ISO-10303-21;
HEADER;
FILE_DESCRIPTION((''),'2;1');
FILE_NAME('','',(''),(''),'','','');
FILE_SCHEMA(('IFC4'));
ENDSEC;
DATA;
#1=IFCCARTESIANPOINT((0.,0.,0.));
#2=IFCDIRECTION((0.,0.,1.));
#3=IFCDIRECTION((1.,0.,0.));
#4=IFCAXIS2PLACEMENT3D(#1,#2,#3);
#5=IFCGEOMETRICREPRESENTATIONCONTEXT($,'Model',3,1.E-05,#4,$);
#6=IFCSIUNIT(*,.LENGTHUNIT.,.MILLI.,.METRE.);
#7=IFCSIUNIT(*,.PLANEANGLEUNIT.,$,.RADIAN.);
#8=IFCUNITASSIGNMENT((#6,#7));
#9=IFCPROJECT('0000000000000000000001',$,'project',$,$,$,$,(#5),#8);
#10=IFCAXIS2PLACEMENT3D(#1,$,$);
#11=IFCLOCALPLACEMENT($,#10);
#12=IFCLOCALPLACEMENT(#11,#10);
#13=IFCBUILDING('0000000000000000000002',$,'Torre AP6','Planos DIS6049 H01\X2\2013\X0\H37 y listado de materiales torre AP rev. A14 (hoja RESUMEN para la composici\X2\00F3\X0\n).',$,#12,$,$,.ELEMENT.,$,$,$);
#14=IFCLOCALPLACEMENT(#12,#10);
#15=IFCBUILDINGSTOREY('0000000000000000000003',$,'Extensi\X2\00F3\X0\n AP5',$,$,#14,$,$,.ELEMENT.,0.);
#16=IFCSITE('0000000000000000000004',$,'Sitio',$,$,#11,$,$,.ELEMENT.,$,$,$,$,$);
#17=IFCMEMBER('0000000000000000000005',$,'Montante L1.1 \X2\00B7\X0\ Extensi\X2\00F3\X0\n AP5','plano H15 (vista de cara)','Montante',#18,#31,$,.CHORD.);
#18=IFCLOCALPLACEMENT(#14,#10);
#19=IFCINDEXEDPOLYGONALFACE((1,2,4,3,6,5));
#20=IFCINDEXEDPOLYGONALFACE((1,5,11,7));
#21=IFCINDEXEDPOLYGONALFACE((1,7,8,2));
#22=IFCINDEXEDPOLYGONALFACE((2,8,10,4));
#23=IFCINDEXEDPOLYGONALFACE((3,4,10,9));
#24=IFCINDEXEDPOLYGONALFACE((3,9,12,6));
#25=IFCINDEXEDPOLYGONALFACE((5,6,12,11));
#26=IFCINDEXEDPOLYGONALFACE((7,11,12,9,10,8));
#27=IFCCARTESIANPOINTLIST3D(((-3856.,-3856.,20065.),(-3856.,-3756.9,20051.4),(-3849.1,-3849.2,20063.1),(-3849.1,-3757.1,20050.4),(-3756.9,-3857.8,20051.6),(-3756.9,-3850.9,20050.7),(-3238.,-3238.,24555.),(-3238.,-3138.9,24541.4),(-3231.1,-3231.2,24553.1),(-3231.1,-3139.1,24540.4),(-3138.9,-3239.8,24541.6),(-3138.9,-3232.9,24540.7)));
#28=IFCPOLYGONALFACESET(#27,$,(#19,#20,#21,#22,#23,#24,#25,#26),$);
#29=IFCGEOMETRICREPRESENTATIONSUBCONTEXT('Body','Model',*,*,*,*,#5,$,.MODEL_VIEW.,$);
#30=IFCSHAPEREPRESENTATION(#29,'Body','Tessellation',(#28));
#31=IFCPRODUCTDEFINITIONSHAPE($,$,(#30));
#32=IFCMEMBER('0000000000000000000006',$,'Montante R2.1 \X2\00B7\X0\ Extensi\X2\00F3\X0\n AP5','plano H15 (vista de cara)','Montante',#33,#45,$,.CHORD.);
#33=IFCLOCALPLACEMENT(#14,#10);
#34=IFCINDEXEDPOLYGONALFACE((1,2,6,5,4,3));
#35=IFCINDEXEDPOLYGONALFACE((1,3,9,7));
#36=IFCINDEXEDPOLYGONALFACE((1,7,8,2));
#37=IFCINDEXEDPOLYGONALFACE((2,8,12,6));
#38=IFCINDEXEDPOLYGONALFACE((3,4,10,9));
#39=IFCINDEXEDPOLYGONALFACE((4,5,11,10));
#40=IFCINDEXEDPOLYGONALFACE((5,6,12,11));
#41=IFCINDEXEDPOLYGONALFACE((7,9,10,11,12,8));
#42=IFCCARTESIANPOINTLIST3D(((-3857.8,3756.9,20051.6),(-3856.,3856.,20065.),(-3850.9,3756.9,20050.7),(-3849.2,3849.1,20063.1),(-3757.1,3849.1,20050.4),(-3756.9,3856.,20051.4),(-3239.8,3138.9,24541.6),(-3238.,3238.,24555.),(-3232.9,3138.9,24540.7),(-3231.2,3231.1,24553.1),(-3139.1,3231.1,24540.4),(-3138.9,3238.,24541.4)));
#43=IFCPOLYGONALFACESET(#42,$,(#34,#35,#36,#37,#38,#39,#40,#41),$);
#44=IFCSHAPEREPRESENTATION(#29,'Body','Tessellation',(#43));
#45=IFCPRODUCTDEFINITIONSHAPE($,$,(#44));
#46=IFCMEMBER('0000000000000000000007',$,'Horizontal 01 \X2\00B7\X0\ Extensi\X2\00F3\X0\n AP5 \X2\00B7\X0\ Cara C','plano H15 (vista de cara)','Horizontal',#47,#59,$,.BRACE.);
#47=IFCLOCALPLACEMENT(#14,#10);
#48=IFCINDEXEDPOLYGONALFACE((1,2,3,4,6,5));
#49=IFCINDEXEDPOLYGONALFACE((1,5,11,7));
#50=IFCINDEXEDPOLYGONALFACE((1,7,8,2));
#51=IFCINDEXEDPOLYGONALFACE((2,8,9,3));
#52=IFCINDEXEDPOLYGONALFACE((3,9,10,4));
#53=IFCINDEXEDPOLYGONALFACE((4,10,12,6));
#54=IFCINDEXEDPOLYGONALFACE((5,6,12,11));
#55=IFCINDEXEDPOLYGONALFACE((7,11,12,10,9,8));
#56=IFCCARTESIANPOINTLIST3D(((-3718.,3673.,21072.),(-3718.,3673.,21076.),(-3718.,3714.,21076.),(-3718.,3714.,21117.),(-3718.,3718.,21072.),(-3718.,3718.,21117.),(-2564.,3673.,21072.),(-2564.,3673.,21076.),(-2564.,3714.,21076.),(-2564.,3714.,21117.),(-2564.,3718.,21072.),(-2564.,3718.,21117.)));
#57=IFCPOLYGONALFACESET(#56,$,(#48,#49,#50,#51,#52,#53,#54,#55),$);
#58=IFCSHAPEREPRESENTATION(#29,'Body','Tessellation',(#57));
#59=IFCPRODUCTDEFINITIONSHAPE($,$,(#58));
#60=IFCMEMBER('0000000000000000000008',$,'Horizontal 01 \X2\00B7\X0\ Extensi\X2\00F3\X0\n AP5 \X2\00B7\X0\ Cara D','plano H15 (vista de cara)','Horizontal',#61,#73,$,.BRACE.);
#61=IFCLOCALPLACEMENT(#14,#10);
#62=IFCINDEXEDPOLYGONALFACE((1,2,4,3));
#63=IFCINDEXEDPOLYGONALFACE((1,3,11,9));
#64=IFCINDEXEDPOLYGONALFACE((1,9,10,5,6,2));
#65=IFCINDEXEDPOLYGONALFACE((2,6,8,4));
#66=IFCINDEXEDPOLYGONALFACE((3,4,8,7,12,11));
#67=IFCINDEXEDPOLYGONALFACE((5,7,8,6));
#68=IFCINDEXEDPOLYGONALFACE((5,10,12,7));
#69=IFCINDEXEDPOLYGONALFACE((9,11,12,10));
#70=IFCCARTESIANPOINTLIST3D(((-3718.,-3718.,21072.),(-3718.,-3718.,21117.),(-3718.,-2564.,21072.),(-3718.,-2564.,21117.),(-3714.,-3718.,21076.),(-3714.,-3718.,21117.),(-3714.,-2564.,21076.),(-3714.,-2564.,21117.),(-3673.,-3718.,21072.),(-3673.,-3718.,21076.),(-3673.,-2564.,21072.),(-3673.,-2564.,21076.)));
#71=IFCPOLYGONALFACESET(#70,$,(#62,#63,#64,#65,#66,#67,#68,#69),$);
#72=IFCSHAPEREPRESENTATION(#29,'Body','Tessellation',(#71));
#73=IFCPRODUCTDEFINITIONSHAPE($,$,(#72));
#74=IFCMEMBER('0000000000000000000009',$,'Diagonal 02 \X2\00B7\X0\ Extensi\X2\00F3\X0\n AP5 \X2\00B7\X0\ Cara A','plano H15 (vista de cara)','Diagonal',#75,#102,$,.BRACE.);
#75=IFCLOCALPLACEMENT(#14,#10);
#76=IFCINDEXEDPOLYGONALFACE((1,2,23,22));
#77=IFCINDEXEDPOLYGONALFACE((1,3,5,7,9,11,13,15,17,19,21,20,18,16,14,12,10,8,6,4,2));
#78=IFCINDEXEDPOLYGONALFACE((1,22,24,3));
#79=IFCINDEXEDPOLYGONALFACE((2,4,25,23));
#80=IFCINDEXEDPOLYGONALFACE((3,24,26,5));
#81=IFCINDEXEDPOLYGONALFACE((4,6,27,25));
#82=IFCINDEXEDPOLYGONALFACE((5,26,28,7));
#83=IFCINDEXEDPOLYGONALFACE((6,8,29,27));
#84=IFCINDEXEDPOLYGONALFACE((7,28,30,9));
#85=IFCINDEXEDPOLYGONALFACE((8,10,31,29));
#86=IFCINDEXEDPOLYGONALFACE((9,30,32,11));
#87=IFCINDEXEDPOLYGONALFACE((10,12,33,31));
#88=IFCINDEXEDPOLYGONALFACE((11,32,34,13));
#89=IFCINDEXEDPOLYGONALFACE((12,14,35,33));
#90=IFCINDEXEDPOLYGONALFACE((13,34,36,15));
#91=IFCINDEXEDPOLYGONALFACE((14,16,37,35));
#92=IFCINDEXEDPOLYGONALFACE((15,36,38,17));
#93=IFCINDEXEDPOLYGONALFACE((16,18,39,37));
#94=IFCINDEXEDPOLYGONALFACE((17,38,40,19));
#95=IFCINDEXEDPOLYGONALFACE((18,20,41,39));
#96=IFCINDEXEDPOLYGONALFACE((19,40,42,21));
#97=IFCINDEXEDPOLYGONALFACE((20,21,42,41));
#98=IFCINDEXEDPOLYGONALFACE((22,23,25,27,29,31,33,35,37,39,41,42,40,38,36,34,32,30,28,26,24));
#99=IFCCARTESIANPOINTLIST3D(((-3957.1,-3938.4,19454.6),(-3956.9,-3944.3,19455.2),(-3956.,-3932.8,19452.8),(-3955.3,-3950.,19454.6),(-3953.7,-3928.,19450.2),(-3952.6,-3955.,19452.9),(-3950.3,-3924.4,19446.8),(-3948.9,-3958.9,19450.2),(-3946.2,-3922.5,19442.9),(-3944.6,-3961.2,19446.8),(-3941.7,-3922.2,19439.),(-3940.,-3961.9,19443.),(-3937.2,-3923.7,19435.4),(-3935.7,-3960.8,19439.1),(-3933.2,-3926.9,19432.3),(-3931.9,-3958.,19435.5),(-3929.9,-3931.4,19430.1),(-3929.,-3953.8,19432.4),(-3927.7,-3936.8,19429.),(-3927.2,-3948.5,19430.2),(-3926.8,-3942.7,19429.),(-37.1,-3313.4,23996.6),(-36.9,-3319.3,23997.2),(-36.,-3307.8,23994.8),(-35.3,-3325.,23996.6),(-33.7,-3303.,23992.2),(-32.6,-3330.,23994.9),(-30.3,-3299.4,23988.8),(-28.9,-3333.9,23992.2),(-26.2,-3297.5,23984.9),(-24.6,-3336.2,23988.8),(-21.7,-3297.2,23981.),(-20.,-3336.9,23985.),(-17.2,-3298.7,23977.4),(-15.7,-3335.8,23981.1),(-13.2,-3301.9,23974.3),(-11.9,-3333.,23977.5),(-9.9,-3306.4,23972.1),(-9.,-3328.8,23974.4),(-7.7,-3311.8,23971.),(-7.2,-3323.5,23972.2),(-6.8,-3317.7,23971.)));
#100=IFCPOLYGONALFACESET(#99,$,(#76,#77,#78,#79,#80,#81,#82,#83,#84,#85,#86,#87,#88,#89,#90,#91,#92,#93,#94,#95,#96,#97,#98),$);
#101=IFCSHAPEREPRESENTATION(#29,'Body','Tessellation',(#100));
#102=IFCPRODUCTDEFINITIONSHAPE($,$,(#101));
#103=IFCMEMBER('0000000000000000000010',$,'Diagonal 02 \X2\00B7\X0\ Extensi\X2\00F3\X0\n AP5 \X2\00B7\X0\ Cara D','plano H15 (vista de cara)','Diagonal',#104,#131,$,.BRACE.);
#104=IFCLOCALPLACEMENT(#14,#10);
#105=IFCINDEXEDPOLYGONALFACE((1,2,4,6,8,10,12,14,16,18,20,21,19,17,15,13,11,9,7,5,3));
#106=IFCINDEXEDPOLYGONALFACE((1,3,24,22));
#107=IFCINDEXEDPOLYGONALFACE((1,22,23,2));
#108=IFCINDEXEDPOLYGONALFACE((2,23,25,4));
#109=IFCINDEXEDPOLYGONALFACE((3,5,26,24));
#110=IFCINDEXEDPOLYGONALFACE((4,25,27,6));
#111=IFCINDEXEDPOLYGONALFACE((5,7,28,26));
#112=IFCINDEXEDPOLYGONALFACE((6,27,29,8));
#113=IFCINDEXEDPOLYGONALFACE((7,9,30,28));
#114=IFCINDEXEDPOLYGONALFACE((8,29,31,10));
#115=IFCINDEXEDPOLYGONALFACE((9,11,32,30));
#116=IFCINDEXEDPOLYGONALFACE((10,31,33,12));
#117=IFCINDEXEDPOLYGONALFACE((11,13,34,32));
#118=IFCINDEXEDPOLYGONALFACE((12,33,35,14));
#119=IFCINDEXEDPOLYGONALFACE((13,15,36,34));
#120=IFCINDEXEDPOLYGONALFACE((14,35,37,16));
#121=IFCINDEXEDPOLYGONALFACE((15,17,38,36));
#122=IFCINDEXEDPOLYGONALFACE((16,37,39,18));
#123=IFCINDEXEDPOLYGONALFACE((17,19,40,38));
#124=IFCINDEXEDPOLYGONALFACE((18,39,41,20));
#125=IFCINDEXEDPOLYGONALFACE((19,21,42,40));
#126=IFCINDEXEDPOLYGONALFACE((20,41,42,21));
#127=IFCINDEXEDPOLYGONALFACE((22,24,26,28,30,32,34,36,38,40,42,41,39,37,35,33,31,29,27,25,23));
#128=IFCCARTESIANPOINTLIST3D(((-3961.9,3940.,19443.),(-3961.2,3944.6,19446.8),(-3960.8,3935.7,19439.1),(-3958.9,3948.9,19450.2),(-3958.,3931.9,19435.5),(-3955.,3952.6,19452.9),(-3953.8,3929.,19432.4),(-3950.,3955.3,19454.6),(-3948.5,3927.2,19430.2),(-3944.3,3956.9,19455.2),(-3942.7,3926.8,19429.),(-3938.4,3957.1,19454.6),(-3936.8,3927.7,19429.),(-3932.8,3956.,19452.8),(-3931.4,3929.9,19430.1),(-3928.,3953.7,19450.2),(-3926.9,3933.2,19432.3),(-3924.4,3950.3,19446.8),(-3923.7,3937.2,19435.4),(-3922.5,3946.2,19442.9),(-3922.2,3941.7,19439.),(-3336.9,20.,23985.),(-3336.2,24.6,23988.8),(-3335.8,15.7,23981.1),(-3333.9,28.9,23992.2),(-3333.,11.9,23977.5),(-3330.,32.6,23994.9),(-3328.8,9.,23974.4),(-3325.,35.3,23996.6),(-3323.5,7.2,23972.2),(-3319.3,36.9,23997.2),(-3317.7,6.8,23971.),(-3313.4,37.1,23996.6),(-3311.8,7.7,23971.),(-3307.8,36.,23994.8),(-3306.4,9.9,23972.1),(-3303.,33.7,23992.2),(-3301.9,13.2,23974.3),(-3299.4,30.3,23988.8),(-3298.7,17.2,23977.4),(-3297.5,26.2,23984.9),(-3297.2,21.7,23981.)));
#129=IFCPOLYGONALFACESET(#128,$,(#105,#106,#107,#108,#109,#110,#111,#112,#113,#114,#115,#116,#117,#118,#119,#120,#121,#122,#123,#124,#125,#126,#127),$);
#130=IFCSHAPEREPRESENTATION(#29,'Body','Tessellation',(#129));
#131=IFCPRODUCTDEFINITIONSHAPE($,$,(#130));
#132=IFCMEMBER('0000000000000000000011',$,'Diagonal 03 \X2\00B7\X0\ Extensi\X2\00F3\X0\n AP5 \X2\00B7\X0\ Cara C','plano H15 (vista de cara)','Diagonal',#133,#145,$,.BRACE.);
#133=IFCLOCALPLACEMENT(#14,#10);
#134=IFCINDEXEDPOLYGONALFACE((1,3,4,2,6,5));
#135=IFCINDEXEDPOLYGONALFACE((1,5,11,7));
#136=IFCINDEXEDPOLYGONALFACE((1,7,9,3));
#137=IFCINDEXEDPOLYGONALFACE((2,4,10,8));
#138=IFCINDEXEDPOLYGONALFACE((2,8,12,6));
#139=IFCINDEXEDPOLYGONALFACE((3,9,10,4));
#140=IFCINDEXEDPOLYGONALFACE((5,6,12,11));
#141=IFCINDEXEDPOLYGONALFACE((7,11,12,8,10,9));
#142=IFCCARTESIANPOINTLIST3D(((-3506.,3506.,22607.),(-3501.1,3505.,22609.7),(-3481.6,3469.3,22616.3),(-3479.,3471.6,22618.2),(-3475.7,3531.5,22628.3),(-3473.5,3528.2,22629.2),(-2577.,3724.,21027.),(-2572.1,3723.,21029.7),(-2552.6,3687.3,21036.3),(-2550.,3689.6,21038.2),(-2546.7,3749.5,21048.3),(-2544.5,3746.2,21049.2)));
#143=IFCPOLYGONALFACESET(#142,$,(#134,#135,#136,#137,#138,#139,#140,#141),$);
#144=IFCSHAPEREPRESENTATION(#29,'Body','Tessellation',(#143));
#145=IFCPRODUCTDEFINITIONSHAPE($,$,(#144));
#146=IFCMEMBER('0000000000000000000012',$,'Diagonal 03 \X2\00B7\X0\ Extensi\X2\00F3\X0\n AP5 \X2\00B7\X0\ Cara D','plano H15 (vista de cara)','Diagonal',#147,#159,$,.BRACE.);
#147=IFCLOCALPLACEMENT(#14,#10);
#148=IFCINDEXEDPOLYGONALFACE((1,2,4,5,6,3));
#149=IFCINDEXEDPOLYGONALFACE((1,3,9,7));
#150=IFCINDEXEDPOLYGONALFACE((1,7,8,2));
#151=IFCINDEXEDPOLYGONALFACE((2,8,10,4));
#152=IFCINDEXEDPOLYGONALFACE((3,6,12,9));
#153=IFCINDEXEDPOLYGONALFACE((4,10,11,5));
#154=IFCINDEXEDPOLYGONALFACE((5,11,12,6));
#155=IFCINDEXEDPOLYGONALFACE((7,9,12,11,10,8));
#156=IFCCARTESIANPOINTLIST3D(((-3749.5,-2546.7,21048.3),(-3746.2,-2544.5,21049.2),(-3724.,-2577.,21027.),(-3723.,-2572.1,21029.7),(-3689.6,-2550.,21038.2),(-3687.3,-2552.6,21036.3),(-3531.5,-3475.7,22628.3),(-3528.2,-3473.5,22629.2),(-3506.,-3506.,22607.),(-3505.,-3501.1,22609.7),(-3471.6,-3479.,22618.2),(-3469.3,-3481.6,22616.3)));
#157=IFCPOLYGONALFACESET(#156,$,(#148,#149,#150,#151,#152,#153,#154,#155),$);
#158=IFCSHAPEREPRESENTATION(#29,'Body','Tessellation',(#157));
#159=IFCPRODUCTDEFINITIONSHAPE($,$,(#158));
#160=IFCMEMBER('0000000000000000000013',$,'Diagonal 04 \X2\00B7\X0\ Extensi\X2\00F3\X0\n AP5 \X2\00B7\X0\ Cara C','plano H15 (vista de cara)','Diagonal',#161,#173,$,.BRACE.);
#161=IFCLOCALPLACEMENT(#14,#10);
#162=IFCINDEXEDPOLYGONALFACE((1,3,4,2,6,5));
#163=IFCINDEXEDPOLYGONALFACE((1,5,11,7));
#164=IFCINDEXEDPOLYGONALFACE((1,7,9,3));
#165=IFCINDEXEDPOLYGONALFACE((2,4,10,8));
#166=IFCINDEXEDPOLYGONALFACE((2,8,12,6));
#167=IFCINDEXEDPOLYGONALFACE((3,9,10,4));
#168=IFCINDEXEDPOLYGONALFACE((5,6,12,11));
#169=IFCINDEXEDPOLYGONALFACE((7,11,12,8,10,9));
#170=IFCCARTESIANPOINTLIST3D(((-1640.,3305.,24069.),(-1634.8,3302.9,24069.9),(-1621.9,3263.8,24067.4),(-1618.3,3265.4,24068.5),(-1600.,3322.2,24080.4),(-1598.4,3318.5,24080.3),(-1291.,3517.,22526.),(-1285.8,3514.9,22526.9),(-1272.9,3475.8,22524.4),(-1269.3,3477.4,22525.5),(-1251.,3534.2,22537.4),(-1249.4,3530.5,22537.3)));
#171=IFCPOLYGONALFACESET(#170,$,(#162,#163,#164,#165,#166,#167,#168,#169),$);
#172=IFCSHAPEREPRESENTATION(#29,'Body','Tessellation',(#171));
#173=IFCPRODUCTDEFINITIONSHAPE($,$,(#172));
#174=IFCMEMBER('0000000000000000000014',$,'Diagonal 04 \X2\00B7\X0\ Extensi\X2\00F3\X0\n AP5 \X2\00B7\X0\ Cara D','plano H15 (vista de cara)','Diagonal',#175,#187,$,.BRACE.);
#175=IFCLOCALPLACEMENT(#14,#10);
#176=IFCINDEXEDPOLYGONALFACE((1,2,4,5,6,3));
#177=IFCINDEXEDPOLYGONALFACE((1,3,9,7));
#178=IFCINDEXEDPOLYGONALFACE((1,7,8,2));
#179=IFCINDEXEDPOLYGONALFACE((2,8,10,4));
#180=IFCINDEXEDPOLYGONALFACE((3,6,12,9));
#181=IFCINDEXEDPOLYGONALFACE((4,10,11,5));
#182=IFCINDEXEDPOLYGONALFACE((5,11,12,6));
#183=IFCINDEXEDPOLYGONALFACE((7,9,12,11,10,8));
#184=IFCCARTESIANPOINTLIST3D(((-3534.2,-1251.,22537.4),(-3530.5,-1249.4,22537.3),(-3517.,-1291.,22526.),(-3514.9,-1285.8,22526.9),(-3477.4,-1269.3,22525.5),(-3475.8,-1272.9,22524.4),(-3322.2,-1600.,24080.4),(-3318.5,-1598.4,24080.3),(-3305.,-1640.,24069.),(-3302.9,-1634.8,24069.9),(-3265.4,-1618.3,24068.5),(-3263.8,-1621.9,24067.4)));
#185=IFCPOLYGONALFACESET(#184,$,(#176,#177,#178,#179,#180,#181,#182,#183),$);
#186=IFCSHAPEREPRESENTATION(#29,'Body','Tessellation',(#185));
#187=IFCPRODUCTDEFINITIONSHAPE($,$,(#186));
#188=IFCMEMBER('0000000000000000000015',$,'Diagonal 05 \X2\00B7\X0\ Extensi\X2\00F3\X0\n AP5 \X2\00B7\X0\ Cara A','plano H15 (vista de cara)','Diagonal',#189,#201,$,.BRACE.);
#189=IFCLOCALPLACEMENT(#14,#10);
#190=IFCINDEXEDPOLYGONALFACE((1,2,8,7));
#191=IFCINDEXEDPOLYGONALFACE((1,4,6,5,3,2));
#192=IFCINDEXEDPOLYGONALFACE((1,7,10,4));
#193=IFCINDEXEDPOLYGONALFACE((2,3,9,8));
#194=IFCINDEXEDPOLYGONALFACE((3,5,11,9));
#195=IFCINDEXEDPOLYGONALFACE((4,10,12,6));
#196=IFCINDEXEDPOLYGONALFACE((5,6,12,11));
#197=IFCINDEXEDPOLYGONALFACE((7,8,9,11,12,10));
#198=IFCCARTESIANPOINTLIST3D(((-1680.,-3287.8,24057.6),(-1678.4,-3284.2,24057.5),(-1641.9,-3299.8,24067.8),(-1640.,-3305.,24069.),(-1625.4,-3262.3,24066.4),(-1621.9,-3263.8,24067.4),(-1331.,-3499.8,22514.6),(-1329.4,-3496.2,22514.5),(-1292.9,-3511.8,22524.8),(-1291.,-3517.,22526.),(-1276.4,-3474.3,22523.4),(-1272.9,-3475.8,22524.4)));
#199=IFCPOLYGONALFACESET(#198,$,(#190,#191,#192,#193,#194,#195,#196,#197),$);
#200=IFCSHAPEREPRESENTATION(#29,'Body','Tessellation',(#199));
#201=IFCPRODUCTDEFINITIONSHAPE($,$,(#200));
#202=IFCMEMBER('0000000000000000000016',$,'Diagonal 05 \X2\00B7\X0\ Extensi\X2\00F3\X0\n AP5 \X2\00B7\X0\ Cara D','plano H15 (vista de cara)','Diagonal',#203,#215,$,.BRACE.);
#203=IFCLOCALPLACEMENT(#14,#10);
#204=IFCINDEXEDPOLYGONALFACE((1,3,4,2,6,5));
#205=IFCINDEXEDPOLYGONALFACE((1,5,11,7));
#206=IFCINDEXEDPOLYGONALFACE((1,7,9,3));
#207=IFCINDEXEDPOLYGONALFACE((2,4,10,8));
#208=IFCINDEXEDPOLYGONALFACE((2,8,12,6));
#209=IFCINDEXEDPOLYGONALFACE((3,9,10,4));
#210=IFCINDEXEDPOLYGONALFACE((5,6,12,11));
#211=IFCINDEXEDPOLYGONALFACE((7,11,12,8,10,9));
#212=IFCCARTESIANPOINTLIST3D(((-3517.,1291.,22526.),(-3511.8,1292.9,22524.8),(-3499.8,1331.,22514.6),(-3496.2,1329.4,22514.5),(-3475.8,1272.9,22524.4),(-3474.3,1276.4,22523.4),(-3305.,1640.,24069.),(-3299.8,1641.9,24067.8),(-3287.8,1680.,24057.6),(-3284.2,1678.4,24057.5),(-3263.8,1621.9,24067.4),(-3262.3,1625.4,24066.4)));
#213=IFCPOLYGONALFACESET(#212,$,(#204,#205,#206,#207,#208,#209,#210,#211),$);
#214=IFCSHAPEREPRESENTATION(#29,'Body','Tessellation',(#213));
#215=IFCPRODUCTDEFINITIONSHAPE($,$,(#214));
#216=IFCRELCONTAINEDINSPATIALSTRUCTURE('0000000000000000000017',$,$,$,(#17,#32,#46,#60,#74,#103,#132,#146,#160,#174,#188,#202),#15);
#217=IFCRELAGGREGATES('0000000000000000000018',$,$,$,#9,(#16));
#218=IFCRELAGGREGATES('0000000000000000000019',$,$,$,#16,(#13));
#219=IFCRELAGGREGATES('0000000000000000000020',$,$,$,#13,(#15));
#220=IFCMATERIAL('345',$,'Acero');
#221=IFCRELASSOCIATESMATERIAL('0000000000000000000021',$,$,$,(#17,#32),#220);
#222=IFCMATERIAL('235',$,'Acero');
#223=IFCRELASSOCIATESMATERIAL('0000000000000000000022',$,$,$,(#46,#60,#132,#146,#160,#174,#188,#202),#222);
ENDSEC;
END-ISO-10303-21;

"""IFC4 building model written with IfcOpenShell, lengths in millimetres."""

from ifc_helpers import new_model, si_unit, frame, frame_2d, origin, origin_with_axes, place, context, subcontext, project, spatial, circle, l_section, extrude, material, element, save


model = new_model("IFC4")

# Units and contexts
model_context = context("Model", 3, precision=1e-05, world=origin_with_axes())
body_context = subcontext(model_context, "Body", "Model", "MODEL_VIEW")
ifc_project = project(units=[si_unit("LENGTHUNIT", "METRE", prefix="MILLI"), si_unit("PLANEANGLEUNIT", "RADIAN")], contexts=[model_context])

# Site, building, storey
site_placement = place(None, origin())
site = spatial("IfcSite", under=ifc_project, at=site_placement, Name="Sitio", CompositionType="ELEMENT")
building_placement = place(site_placement, origin())
building = spatial("IfcBuilding", under=site, at=building_placement, Name="Torre AP6", Description="Planos DIS6049 H01–H37 y listado de materiales torre AP rev. A14 (hoja RESUMEN para la composición).", CompositionType="ELEMENT")
storey_placement = place(building_placement, origin())
storey = spatial("IfcBuildingStorey", under=building, at=storey_placement, Name="Extensión AP5", CompositionType="ELEMENT", Elevation=0.0)

# Members
ifc_material_1 = material(Name="345", Category="Acero")
for number, where, z_axis, x_axis, name in (
    (1, (-3856.0, -3856.0, 20065.0), (0.135104, 0.135104, 0.981577), (0.990831, -0.018422, -0.133842), "Montante L1.1 · Extensión AP5"),
    (2, (-3856.0, 3856.0, 20065.0), (0.135104, -0.135104, 0.981577), (-0.018422, -0.990831, -0.133842), "Montante R2.1 · Extensión AP5"),
):
    element("IfcMember", number, at=place(storey_placement, frame(where, z_axis=z_axis, x_axis=x_axis)), inside=storey, material=ifc_material_1, Name=name, Description="plano H15 (vista de cara)", ObjectType="Montante", PredefinedType="CHORD", context=body_context, shape_type="SweptSolid", body=[
        extrude(l_section(Depth=100.0, Width=100.0, Thickness=7.0, at=frame_2d((50.0, 50.0))), None, (0.0, 0.0, 1.0), 4574.3),
    ])
ifc_material_2 = material(Name="235", Category="Acero")
for number, where, z_axis, x_axis, name in (
    (3, (-2564.0, 3718.0, 21072.0), (-1.0, 0.0, 0.0), (0.0, -1.0, 0.0), "Horizontal 01 · Extensión AP5 · Cara C"),
    (4, (-3718.0, -2564.0, 21072.0), (0.0, -1.0, 0.0), (1.0, 0.0, 0.0), "Horizontal 01 · Extensión AP5 · Cara D"),
):
    element("IfcMember", number, at=place(storey_placement, frame(where, z_axis=z_axis, x_axis=x_axis)), inside=storey, material=ifc_material_2, Name=name, Description="plano H15 (vista de cara)", ObjectType="Horizontal", PredefinedType="BRACE", context=body_context, shape_type="SweptSolid", body=[
        extrude(l_section(Depth=45.0, Width=45.0, Thickness=4.0, at=frame_2d((22.5, 22.5))), None, (0.0, 0.0, 1.0), 1154.0),
    ])
for number, where, z_axis, x_axis, name in (
    (5, (-3942.0, -3942.0, 19442.0), (0.649852, 0.103612, 0.752966), (0.237889, 0.913165, -0.330967), "Diagonal 02 · Extensión AP5 · Cara A"),
    (6, (-3942.0, 3942.0, 19442.0), (0.103612, -0.649852, 0.752966), (0.913165, -0.237889, -0.330967), "Diagonal 02 · Extensión AP5 · Cara D"),
):
    element("IfcMember", number, at=place(storey_placement, frame(where, z_axis=z_axis, x_axis=x_axis)), inside=storey, Name=name, Description="plano H15 (vista de cara)", ObjectType="Diagonal", PredefinedType="BRACE", context=body_context, shape_type="SweptSolid", body=[
        extrude(circle(Radius=20.0), None, (0.0, 0.0, 1.0), 6032.1),
    ])
for number, where, z_axis, x_axis, name in (
    (7, (-2577.0, 3724.0, 21027.0), (-0.503306, -0.118106, 0.855999), (0.541181, -0.815359, 0.205702), "Diagonal 03 · Extensión AP5 · Cara C"),
    (8, (-3724.0, -2577.0, 21027.0), (0.118106, -0.503306, 0.855999), (0.815359, 0.541181, 0.205702), "Diagonal 03 · Extensión AP5 · Cara D"),
):
    element("IfcMember", number, at=place(storey_placement, frame(where, z_axis=z_axis, x_axis=x_axis)), inside=storey, material=ifc_material_2, Name=name, Description="plano H15 (vista de cara)", ObjectType="Diagonal", PredefinedType="BRACE", context=body_context, shape_type="SweptSolid", body=[
        extrude(l_section(Depth=45.0, Width=45.0, Thickness=4.0, at=frame_2d((22.5, 22.5))), None, (0.0, 0.0, 1.0), 1845.8),
    ])
for number, where, z_axis, x_axis, name in (
    (9, (-1291.0, 3517.0, 22526.0), (-0.218655, -0.132822, 0.96672), (0.402816, -0.914628, -0.034555), "Diagonal 04 · Extensión AP5 · Cara C"),
    (10, (-3517.0, -1291.0, 22526.0), (0.132822, -0.218655, 0.96672), (0.914628, 0.402816, -0.034555), "Diagonal 04 · Extensión AP5 · Cara D"),
    (11, (-1291.0, -3517.0, 22526.0), (-0.218655, 0.132822, 0.96672), (0.402816, 0.914628, -0.034555), "Diagonal 05 · Extensión AP5 · Cara A"),
    (12, (-3517.0, 1291.0, 22526.0), (0.132822, 0.218655, 0.96672), (0.914628, -0.402816, -0.034555), "Diagonal 05 · Extensión AP5 · Cara D"),
):
    element("IfcMember", number, at=place(storey_placement, frame(where, z_axis=z_axis, x_axis=x_axis)), inside=storey, material=ifc_material_2, Name=name, Description="plano H15 (vista de cara)", ObjectType="Diagonal", PredefinedType="BRACE", context=body_context, shape_type="SweptSolid", body=[
        extrude(l_section(Depth=45.0, Width=45.0, Thickness=4.0, at=frame_2d((22.5, 22.5))), None, (0.0, 0.0, 1.0), 1596.1),
    ])

save(model, "model.ifc")
